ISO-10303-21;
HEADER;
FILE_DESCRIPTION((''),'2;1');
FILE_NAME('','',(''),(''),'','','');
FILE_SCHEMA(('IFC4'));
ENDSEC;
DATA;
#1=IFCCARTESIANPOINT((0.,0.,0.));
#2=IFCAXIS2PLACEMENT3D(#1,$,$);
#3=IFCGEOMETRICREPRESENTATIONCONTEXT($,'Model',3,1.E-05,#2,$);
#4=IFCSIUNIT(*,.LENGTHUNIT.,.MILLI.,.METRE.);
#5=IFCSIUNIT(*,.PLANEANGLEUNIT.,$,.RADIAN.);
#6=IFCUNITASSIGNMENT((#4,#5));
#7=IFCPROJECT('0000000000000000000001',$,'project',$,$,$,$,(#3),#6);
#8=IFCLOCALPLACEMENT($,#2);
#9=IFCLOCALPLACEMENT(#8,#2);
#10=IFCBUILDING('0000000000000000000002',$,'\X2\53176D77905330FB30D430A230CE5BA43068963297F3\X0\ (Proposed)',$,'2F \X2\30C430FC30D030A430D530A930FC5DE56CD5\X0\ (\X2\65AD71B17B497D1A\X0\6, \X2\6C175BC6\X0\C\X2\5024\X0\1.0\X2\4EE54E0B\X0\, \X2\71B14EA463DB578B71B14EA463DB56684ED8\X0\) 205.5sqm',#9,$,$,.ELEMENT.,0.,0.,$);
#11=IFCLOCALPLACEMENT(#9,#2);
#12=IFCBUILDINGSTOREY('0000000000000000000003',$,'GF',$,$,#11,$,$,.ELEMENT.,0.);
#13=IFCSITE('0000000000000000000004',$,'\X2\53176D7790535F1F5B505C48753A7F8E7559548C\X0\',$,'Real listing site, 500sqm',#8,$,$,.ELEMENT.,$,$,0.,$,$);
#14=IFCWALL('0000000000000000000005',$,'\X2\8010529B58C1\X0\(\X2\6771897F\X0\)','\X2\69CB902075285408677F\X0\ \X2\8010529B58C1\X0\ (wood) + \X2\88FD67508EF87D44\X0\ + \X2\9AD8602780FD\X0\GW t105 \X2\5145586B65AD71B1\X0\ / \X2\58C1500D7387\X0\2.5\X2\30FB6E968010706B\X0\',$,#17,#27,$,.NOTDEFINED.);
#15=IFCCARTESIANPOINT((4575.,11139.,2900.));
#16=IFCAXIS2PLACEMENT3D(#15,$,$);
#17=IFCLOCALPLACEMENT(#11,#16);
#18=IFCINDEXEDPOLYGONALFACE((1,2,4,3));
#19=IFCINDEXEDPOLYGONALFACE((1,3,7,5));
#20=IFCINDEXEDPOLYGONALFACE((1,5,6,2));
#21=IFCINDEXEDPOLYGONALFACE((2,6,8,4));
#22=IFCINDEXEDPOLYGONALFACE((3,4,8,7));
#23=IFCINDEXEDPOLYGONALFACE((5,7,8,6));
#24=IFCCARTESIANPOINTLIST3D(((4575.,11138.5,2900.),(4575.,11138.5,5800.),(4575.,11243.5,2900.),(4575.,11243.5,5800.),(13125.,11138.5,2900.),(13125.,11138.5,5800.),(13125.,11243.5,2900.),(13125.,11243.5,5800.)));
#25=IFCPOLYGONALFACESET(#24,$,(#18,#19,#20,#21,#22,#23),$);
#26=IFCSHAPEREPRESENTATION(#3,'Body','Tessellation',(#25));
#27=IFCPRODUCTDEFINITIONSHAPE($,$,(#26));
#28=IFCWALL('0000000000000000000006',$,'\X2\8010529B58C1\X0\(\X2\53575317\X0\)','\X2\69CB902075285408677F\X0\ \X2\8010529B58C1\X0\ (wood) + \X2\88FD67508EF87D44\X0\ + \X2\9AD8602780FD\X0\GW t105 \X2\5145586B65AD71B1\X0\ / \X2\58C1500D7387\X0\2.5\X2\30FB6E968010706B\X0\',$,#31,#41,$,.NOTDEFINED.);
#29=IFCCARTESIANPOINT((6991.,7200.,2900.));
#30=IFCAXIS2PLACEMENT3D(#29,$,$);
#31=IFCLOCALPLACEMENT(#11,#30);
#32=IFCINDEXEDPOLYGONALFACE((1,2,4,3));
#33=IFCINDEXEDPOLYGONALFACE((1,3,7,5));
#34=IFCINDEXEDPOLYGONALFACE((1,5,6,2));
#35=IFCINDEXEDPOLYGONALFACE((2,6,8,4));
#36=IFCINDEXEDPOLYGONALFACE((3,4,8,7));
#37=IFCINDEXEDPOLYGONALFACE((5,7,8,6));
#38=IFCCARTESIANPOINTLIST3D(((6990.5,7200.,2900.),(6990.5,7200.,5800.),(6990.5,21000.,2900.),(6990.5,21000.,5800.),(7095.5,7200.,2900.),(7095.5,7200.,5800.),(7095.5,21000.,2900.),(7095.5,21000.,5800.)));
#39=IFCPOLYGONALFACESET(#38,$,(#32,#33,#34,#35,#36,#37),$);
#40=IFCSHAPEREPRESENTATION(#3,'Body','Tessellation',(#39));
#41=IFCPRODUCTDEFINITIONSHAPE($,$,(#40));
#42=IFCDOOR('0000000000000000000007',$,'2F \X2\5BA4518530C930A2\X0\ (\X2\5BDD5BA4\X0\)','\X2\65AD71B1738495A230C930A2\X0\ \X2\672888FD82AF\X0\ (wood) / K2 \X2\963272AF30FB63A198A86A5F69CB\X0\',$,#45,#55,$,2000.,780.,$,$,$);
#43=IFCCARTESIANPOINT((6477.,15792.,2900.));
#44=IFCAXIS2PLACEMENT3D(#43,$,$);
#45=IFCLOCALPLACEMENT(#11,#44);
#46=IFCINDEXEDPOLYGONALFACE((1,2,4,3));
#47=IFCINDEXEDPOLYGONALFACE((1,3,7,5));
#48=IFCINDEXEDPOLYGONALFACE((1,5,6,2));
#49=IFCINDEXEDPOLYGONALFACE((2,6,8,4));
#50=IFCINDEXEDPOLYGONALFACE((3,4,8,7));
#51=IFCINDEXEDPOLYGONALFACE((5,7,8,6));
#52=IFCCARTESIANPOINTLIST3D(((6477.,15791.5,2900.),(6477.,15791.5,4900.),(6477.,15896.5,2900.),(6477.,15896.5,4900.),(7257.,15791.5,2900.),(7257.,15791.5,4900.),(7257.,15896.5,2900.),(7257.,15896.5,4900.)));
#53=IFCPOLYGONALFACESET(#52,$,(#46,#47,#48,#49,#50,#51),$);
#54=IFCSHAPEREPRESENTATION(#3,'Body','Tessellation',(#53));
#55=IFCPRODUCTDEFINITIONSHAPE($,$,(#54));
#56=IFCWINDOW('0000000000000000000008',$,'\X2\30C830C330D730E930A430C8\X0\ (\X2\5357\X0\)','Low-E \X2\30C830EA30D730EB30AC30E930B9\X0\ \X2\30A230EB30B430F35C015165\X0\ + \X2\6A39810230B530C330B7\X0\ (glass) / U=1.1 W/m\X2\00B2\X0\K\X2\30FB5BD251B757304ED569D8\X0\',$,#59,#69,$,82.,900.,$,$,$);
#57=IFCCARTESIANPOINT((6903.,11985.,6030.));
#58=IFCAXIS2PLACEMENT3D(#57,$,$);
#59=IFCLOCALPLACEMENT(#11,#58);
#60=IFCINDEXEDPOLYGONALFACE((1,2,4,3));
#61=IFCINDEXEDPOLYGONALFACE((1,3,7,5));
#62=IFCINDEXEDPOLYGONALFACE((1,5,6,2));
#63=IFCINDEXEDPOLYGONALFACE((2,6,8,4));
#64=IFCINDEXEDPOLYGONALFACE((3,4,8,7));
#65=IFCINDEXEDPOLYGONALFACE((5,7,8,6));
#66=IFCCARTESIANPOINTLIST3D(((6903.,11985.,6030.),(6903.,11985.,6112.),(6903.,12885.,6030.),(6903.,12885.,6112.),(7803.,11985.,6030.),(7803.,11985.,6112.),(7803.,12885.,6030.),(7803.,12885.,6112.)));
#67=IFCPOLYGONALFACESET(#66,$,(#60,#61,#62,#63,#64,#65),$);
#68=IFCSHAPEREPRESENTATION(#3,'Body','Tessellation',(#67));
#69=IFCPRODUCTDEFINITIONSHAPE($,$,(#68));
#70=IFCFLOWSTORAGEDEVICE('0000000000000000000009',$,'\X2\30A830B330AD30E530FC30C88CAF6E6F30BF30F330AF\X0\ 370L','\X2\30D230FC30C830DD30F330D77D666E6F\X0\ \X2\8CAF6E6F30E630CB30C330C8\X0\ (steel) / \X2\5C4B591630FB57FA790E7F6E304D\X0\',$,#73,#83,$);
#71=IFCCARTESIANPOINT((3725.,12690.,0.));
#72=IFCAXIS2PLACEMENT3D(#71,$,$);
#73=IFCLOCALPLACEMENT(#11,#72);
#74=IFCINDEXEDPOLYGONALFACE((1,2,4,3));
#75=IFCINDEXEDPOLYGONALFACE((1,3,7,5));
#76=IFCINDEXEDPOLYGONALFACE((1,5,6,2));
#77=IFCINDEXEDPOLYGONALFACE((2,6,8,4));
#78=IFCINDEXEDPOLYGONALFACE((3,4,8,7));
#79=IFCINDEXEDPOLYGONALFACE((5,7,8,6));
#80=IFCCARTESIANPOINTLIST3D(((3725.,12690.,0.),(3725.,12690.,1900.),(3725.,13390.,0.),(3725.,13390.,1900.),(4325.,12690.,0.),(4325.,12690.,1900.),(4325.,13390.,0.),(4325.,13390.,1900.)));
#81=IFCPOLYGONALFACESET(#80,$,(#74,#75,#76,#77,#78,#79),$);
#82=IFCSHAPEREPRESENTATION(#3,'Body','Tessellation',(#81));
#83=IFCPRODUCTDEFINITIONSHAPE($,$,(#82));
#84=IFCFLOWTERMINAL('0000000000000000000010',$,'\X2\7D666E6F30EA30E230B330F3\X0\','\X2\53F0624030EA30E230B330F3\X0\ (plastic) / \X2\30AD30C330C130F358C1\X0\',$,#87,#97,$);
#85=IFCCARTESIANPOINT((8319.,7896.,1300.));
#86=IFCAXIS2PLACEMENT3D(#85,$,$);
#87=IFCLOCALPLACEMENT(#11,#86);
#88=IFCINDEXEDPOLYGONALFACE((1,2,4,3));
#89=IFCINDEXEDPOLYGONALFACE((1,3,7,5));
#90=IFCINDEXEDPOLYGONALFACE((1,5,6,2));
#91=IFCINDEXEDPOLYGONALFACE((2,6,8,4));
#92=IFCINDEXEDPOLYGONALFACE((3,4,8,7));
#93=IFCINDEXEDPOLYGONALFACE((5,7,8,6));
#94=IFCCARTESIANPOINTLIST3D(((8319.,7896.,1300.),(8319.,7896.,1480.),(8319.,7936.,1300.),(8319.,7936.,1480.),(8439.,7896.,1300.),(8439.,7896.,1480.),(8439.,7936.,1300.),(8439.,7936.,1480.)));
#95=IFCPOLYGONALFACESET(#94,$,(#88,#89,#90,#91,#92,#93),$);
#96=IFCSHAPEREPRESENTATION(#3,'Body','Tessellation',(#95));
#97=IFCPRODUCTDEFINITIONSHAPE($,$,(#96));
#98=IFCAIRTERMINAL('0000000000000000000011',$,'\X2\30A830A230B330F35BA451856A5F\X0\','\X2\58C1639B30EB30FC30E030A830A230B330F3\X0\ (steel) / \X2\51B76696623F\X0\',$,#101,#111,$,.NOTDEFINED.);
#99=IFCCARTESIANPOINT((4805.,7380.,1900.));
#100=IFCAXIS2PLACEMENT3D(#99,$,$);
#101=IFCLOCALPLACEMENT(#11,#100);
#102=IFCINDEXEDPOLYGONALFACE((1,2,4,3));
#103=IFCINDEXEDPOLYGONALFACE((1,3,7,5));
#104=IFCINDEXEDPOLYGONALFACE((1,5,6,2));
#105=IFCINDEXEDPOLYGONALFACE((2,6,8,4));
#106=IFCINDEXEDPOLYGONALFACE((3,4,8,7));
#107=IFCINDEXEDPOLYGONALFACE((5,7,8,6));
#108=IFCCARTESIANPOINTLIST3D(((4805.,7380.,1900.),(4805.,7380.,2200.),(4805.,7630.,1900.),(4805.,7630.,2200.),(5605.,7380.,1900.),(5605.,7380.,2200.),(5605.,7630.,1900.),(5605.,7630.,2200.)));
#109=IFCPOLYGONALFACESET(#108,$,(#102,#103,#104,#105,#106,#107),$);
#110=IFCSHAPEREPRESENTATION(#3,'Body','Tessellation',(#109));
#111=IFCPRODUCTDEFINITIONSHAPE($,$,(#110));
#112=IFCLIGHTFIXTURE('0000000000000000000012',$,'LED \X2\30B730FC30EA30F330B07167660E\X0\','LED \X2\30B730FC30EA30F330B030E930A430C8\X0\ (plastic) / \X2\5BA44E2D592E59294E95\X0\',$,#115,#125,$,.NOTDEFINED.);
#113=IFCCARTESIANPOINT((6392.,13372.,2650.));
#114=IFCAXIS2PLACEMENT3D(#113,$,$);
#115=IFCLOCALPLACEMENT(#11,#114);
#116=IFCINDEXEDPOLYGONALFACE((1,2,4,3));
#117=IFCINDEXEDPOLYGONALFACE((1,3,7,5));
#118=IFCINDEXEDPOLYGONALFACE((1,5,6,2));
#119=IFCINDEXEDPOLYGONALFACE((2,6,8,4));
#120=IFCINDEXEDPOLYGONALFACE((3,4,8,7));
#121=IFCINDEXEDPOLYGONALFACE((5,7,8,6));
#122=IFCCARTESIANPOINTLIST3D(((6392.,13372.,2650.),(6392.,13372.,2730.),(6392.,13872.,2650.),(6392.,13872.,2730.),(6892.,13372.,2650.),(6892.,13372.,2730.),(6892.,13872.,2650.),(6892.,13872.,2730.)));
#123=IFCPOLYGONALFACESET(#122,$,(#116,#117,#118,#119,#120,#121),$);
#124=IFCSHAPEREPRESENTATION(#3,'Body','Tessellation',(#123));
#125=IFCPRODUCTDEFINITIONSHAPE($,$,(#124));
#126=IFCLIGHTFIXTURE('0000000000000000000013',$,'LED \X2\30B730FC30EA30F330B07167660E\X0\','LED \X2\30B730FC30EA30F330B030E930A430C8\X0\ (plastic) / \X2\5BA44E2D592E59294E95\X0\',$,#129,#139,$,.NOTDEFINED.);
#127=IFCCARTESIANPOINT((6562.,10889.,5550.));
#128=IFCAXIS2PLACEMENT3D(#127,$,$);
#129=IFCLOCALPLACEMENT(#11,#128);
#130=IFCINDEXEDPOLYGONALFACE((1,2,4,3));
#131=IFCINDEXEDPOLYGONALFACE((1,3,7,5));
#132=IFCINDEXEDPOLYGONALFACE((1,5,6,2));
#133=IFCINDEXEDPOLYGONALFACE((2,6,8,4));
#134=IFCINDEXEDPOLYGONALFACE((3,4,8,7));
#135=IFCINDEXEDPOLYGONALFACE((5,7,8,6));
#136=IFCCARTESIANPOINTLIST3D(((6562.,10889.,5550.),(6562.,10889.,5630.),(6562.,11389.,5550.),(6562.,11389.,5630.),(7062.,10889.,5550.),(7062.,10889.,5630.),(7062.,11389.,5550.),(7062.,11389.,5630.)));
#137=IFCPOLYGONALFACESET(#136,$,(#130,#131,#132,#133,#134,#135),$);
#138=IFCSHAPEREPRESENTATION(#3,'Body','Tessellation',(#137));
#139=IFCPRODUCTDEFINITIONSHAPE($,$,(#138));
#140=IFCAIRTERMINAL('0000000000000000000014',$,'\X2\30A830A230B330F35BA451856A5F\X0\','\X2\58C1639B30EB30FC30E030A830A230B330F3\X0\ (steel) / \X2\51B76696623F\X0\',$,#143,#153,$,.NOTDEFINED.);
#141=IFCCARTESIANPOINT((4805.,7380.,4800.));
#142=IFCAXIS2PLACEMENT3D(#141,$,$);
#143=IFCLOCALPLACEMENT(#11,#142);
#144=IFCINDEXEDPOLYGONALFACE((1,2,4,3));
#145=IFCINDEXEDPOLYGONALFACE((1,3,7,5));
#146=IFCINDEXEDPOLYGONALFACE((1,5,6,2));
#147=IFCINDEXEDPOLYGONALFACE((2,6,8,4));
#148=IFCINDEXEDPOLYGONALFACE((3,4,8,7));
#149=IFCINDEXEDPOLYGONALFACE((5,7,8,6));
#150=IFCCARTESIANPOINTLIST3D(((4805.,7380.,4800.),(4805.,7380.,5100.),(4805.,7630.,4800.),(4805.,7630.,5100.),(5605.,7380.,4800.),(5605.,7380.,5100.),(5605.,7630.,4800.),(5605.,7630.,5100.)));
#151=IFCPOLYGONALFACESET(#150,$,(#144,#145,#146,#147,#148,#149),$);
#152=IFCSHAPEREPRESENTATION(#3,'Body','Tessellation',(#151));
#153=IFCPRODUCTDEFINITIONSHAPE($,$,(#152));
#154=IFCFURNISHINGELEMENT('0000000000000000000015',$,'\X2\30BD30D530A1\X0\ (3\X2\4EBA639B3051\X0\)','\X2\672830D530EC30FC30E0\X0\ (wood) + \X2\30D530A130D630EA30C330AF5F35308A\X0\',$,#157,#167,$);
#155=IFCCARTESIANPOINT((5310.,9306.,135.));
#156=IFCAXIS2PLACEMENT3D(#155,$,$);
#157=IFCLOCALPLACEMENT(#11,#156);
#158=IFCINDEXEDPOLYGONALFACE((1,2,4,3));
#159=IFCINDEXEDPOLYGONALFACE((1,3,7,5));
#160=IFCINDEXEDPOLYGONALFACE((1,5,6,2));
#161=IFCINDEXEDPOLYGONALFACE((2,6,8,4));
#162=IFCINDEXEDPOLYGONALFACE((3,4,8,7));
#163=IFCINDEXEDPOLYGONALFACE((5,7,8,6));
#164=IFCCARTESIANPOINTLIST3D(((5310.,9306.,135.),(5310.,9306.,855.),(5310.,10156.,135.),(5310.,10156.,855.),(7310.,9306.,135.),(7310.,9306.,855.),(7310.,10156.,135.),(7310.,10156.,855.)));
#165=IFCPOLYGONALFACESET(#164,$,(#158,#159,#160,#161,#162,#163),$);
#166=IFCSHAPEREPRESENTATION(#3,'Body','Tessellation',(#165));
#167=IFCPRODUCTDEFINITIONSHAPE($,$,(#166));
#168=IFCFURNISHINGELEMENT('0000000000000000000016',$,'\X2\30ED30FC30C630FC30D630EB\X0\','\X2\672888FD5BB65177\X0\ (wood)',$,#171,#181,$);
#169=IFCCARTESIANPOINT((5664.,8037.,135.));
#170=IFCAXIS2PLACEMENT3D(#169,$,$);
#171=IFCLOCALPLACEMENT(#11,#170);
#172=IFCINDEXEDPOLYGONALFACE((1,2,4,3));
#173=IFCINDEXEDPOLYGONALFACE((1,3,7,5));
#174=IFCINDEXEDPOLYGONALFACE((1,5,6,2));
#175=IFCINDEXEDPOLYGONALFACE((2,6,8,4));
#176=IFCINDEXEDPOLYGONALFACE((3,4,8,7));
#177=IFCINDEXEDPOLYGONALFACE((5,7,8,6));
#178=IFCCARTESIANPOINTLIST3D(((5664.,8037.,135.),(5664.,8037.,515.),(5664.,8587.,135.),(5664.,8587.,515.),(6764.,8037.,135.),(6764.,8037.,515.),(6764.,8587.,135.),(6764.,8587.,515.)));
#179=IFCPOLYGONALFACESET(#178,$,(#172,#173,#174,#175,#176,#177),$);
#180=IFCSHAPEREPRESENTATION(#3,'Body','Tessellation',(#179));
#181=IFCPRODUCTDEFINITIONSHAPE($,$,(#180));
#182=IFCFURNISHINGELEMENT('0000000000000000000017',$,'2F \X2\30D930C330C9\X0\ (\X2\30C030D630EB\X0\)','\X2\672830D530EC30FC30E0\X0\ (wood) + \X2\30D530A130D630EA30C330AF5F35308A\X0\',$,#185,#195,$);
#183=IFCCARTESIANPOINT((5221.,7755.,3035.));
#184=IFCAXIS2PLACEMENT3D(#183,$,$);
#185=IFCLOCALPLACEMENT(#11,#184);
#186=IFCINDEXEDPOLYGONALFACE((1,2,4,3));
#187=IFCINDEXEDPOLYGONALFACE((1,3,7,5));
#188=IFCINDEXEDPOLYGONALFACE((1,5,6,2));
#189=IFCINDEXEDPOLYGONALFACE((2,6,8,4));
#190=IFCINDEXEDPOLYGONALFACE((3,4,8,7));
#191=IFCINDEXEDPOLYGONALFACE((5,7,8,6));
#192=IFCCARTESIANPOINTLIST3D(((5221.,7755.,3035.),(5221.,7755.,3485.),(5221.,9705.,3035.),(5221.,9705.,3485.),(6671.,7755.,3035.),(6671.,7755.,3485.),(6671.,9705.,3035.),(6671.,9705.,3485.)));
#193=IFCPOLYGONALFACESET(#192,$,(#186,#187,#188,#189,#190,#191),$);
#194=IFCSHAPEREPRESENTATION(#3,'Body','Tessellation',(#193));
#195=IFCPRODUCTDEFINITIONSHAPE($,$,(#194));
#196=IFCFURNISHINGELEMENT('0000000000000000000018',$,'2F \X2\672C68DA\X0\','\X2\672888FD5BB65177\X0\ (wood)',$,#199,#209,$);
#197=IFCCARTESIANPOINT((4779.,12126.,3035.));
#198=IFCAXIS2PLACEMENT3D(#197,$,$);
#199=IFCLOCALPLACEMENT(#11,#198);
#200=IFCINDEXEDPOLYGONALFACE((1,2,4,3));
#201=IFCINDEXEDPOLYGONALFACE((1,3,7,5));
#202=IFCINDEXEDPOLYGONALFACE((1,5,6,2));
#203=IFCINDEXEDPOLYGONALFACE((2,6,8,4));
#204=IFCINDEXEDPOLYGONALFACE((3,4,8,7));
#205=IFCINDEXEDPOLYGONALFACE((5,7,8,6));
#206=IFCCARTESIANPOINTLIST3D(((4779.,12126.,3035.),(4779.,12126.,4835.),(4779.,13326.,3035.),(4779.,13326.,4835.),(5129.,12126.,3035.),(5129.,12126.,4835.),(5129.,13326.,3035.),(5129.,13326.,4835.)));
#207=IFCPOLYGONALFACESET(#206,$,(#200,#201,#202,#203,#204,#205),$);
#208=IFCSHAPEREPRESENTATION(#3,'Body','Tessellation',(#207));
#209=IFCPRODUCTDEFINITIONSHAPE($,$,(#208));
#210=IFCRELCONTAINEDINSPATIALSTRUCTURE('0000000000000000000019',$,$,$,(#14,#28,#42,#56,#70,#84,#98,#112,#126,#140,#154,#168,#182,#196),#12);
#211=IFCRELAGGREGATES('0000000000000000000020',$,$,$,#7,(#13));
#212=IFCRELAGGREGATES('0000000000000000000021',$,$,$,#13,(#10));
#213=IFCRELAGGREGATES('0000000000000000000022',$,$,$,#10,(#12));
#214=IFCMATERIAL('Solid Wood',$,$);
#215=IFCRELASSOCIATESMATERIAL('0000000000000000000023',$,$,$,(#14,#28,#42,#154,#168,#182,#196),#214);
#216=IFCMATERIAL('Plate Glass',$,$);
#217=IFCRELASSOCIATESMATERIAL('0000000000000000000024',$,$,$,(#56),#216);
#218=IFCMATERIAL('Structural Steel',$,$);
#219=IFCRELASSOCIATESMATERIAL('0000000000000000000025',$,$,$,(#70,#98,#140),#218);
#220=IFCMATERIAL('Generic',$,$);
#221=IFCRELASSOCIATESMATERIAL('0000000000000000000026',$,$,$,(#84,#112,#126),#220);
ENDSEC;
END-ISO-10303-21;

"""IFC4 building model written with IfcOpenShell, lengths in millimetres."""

from ifc_helpers import new_model, si_unit, frame, frame_2d, origin, place, context, project, spatial, rectangle, extrude, material, element, fill, save


model = new_model("IFC4")

# Units and contexts
model_context = context("Model", 3, precision=1e-05, world=origin())
ifc_project = project(units=[si_unit("LENGTHUNIT", "METRE", prefix="MILLI"), si_unit("PLANEANGLEUNIT", "RADIAN")], contexts=[model_context])

# Site, building, storey
site_placement = place(None, origin())
site = spatial("IfcSite", under=ifc_project, at=site_placement, Name="北海道弟子屈町美留和", ObjectType="Real listing site, 500sqm", CompositionType="ELEMENT", RefElevation=0.0)
building_placement = place(site_placement, origin())
building = spatial("IfcBuilding", under=site, at=building_placement, Name="北海道・ピアノ室と防音 (Proposed)", ObjectType="2F ツーバイフォー工法 (断熱等級6, 気密C値1.0以下, 熱交換型熱交換器付) 205.5sqm", CompositionType="ELEMENT", ElevationOfRefHeight=0.0, ElevationOfTerrain=0.0)
storey_placement = place(building_placement, origin())
storey = spatial("IfcBuildingStorey", under=building, at=storey_placement, Name="GF", CompositionType="ELEMENT", Elevation=0.0)

# Shared definitions
ifc_material_1 = material(Name="Solid Wood")

# Wall
wall_1_placement = place(storey_placement, frame((4575.0, 11139.0, 2900.0)))
element("IfcWall", 1, at=wall_1_placement, inside=storey, material=ifc_material_1, Name="耐力壁(東西)", Description="構造用合板 耐力壁 (wood) + 製材軸組 + 高性能GW t105 充填断熱 / 壁倍率2.5・準耐火", PredefinedType="NOTDEFINED", context=model_context, shape_type="SweptSolid", body=[
    extrude(rectangle(XDim=8550.0, YDim=105.0, at=frame_2d((4275.0, 52.0))), frame((4575.0, 11139.0, 2900.0)), (0.0, 0.0, 1.0), 2900.0),
])

# Wall, opening, door
wall_2_placement = place(storey_placement, frame((6991.0, 7200.0, 2900.0)))
wall_2 = element("IfcWall", 2, at=wall_2_placement, inside=storey, material=ifc_material_1, Name="耐力壁(南北)", Description="構造用合板 耐力壁 (wood) + 製材軸組 + 高性能GW t105 充填断熱 / 壁倍率2.5・準耐火", PredefinedType="NOTDEFINED", context=model_context, shape_type="SweptSolid", body=[
    extrude(rectangle(XDim=105.0, YDim=13800.0, at=frame_2d((52.0, 6900.0))), frame((6991.0, 7200.0, 2900.0)), (0.0, 0.0, 1.0), 2900.0),
])
opening_placement = place(storey_placement, frame((6477.0, 15792.0, 2900.0)))
opening = element("IfcOpeningElement", 3, at=opening_placement, cuts=wall_2, PredefinedType="NOTDEFINED", context=model_context, shape_type="SweptSolid", body=[
    extrude(rectangle(XDim=780.0, YDim=105.0, at=frame_2d((390.0, 52.0))), frame((6477.0, 15792.0, 2900.0)), (0.0, 0.0, 1.0), 2000.0),
])
door_placement = place(storey_placement, frame((6477.0, 15792.0, 2900.0)))
door = element("IfcDoor", 4, at=door_placement, inside=storey, material=ifc_material_1, Name="2F 室内ドア (寝室)", Description="断熱玄関ドア 木製芯 (wood) / K2 防犯・採風機構", OverallHeight=2000.0, OverallWidth=780.0, context=model_context, shape_type="SweptSolid", body=[
    extrude(rectangle(XDim=780.0, YDim=105.0, at=frame_2d((390.0, 52.0))), frame((6477.0, 15792.0, 2900.0)), (0.0, 0.0, 1.0), 2000.0),
])
fill(opening, door)

# Window
ifc_material_2 = material(Name="Plate Glass")
window_placement = place(storey_placement, frame((6903.0, 11985.0, 6030.0)))
element("IfcWindow", 5, at=window_placement, inside=storey, material=ifc_material_2, Name="トップライト (南)", Description="Low-E トリプルガラス アルゴン封入 + 樹脂サッシ (glass) / U=1.1 W/m²K・寒冷地仕様", OverallHeight=82.0, OverallWidth=900.0, context=model_context, shape_type="SweptSolid", body=[
    extrude(rectangle(XDim=900.0, YDim=900.0, at=frame_2d((450.0, 450.0))), frame((6903.0, 11985.0, 6030.0)), (0.0, 0.0, 1.0), 82.0),
])

# Flow storage device
ifc_material_3 = material(Name="Structural Steel")
flow_storage_device_placement = place(storey_placement, frame((3725.0, 12690.0, 0.0)))
element("IfcFlowStorageDevice", 6, at=flow_storage_device_placement, inside=storey, material=ifc_material_3, Name="エコキュート貯湯タンク 370L", Description="ヒートポンプ給湯 貯湯ユニット (steel) / 屋外・基礎置き", context=model_context, shape_type="SweptSolid", body=[
    extrude(rectangle(XDim=600.0, YDim=700.0, at=frame_2d((300.0, 350.0))), frame((3725.0, 12690.0, 0.0)), (0.0, 0.0, 1.0), 1900.0),
])

# Flow terminal
ifc_material_4 = material(Name="Generic")
flow_terminal_placement = place(storey_placement, frame((8319.0, 7896.0, 1300.0)))
element("IfcFlowTerminal", 7, at=flow_terminal_placement, inside=storey, material=ifc_material_4, Name="給湯リモコン", Description="台所リモコン (plastic) / キッチン壁", context=model_context, shape_type="SweptSolid", body=[
    extrude(rectangle(XDim=120.0, YDim=40.0, at=frame_2d((60.0, 20.0))), frame((8319.0, 7896.0, 1300.0)), (0.0, 0.0, 1.0), 180.0),
])

# Air terminal
air_terminal_1_placement = place(storey_placement, frame((4805.0, 7380.0, 1900.0)))
element("IfcAirTerminal", 8, at=air_terminal_1_placement, inside=storey, material=ifc_material_3, Name="エアコン室内機", Description="壁掛ルームエアコン (steel) / 冷暖房", PredefinedType="NOTDEFINED", context=model_context, shape_type="SweptSolid", body=[
    extrude(rectangle(XDim=800.0, YDim=250.0, at=frame_2d((400.0, 125.0))), frame((4805.0, 7380.0, 1900.0)), (0.0, 0.0, 1.0), 300.0),
])

# Light fixtures
light_fixture_1_placement = place(storey_placement, frame((6392.0, 13372.0, 2650.0)))
element("IfcLightFixture", 9, at=light_fixture_1_placement, inside=storey, material=ifc_material_4, Name="LED シーリング照明", Description="LED シーリングライト (plastic) / 室中央天井", PredefinedType="NOTDEFINED", context=model_context, shape_type="SweptSolid", body=[
    extrude(rectangle(XDim=500.0, YDim=500.0, at=frame_2d((250.0, 250.0))), frame((6392.0, 13372.0, 2650.0)), (0.0, 0.0, 1.0), 80.0),
])
light_fixture_2_placement = place(storey_placement, frame((6562.0, 10889.0, 5550.0)))
element("IfcLightFixture", 10, at=light_fixture_2_placement, inside=storey, material=ifc_material_4, Name="LED シーリング照明", Description="LED シーリングライト (plastic) / 室中央天井", PredefinedType="NOTDEFINED", context=model_context, shape_type="SweptSolid", body=[
    extrude(rectangle(XDim=500.0, YDim=500.0, at=frame_2d((250.0, 250.0))), frame((6562.0, 10889.0, 5550.0)), (0.0, 0.0, 1.0), 80.0),
])

# Air terminal
air_terminal_2_placement = place(storey_placement, frame((4805.0, 7380.0, 4800.0)))
element("IfcAirTerminal", 11, at=air_terminal_2_placement, inside=storey, material=ifc_material_3, Name="エアコン室内機", Description="壁掛ルームエアコン (steel) / 冷暖房", PredefinedType="NOTDEFINED", context=model_context, shape_type="SweptSolid", body=[
    extrude(rectangle(XDim=800.0, YDim=250.0, at=frame_2d((400.0, 125.0))), frame((4805.0, 7380.0, 4800.0)), (0.0, 0.0, 1.0), 300.0),
])

# Furnishing elements
furnishing_1_placement = place(storey_placement, frame((5310.0, 9306.0, 135.0)))
element("IfcFurnishingElement", 12, at=furnishing_1_placement, inside=storey, material=ifc_material_1, Name="ソファ (3人掛け)", Description="木フレーム (wood) + ファブリック張り", context=model_context, shape_type="SweptSolid", body=[
    extrude(rectangle(XDim=2000.0, YDim=850.0, at=frame_2d((1000.0, 425.0))), frame((5310.0, 9306.0, 135.0)), (0.0, 0.0, 1.0), 720.0),
])
furnishing_2_placement = place(storey_placement, frame((5664.0, 8037.0, 135.0)))
element("IfcFurnishingElement", 13, at=furnishing_2_placement, inside=storey, material=ifc_material_1, Name="ローテーブル", Description="木製家具 (wood)", context=model_context, shape_type="SweptSolid", body=[
    extrude(rectangle(XDim=1100.0, YDim=550.0, at=frame_2d((550.0, 275.0))), frame((5664.0, 8037.0, 135.0)), (0.0, 0.0, 1.0), 380.0),
])
furnishing_3_placement = place(storey_placement, frame((5221.0, 7755.0, 3035.0)))
element("IfcFurnishingElement", 14, at=furnishing_3_placement, inside=storey, material=ifc_material_1, Name="2F ベッド (ダブル)", Description="木フレーム (wood) + ファブリック張り", context=model_context, shape_type="SweptSolid", body=[
    extrude(rectangle(XDim=1450.0, YDim=1950.0, at=frame_2d((725.0, 975.0))), frame((5221.0, 7755.0, 3035.0)), (0.0, 0.0, 1.0), 450.0),
])
furnishing_4_placement = place(storey_placement, frame((4779.0, 12126.0, 3035.0)))
element("IfcFurnishingElement", 15, at=furnishing_4_placement, inside=storey, material=ifc_material_1, Name="2F 本棚", Description="木製家具 (wood)", context=model_context, shape_type="SweptSolid", body=[
    extrude(rectangle(XDim=350.0, YDim=1200.0, at=frame_2d((175.0, 600.0))), frame((4779.0, 12126.0, 3035.0)), (0.0, 0.0, 1.0), 1800.0),
])

save(model, "model.ifc")
